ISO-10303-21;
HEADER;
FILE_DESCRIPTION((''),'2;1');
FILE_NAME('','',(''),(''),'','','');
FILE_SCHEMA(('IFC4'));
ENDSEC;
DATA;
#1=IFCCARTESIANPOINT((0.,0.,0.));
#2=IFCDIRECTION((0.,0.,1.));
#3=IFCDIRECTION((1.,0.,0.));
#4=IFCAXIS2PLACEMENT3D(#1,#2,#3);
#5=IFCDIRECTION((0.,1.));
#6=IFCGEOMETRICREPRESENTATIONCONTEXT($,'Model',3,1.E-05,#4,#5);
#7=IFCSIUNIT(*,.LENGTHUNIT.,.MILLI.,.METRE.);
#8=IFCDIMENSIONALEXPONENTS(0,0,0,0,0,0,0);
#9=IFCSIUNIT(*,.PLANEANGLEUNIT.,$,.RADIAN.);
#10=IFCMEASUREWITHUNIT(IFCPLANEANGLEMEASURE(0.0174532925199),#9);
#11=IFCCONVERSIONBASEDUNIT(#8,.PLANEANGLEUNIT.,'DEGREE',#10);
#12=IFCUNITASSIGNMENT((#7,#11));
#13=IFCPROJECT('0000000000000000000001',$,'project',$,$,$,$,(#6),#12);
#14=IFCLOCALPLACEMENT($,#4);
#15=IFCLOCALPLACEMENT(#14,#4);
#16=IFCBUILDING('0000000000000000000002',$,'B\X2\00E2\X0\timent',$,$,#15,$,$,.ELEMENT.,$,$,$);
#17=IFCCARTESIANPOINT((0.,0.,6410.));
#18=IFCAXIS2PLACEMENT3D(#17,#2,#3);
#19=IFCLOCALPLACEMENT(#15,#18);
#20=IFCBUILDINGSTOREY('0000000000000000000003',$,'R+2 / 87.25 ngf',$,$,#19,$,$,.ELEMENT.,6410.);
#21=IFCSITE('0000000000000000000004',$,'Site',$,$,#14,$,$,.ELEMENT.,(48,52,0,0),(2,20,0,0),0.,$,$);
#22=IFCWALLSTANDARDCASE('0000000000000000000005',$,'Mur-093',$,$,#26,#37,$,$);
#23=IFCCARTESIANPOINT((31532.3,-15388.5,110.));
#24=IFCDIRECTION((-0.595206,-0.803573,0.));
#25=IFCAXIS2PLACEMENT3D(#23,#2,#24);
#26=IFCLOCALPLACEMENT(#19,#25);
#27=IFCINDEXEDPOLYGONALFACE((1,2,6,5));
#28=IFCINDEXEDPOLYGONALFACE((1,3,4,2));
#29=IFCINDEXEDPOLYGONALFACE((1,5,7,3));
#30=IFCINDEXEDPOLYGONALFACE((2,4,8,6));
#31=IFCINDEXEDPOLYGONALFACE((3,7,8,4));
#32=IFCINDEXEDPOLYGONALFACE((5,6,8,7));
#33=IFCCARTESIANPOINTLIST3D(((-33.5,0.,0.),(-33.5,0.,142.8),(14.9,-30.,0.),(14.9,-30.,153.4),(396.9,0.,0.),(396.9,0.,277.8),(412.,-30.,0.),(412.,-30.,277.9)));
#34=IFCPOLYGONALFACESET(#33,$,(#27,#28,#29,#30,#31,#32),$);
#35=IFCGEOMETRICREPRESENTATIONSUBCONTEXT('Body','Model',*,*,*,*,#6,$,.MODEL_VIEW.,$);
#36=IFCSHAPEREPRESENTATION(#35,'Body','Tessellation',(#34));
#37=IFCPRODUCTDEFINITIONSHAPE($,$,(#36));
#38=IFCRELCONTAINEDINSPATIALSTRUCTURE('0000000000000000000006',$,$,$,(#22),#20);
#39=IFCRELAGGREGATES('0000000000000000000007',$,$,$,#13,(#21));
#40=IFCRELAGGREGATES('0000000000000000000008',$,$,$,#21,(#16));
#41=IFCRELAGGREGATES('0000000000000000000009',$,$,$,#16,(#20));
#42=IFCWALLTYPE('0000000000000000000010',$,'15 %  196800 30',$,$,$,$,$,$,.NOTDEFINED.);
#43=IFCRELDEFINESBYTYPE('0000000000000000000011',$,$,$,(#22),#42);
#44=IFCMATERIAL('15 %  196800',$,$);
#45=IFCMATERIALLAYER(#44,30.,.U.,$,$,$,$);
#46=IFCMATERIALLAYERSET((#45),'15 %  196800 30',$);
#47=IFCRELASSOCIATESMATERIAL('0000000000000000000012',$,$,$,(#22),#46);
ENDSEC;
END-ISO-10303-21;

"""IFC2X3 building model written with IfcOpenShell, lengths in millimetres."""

from ifc_helpers import new_model, entity, si_unit, converted_unit, direction, frame, origin_with_axes, place, context, subcontext, project, spatial, polyline, outline, extrude, clip, halfspace, material, layer, layer_set, layer_usage, type_object, element, save


model = new_model("IFC2X3")

# Units and contexts
model_context = context("Model", 3, precision=1e-05, world=origin_with_axes(), true_north=direction((0.0, 1.0)))
body_context = subcontext(model_context, "Body", "Model", "MODEL_VIEW")
ifc_project = project(units=[si_unit("LENGTHUNIT", "METRE", prefix="MILLI"), converted_unit("PLANEANGLEUNIT", "DEGREE", entity("IfcPlaneAngleMeasure", 0.0174532925199), si_unit("PLANEANGLEUNIT", "RADIAN"), dimensions=[0, 0, 0, 0, 0, 0, 0])], contexts=[model_context])

# Site, building, storey
site_placement = place(None, origin_with_axes())
site = spatial("IfcSite", under=ifc_project, at=site_placement, Name="Site", CompositionType="ELEMENT", RefLatitude=(48, 52, 0, 0), RefLongitude=(2, 20, 0, 0), RefElevation=0.0)
building_placement = place(site_placement, origin_with_axes())
building = spatial("IfcBuilding", under=site, at=building_placement, Name="Bâtiment", CompositionType="ELEMENT")
storey_placement = place(building_placement, frame((0.0, 0.0, 6410.0), z_axis=(0.0, 0.0, 1.0), x_axis=(1.0, 0.0, 0.0)))
storey = spatial("IfcBuildingStorey", under=building, at=storey_placement, Name="R+2 / 87.25 ngf", CompositionType="ELEMENT", Elevation=6410.0)

# Wall
ifc_material_1 = material(Name="15 %  196800")
ifc_layer = layer(ifc_material_1, 30.0, ventilated="UNKNOWN")
ifc_layer_set = layer_set([ifc_layer], Name="15 %  196800 30")
ifc_layer_usage = layer_usage(ifc_layer_set, "AXIS2", "POSITIVE", -30.0)
wall_type = type_object("IfcWallType", Name="15 %  196800 30", PredefinedType="NOTDEFINED")
wall_placement = place(storey_placement, frame((31532.3, -15388.5, 110.0), z_axis=(0.0, 0.0, 1.0), x_axis=(-0.595206, -0.803573, 0.0)))
element("IfcWallStandardCase", 1, at=wall_placement, inside=storey, type_object=wall_type, material=ifc_layer_usage, Name="Mur-093", context=body_context, shape_type="Clipping", body=[
    clip(extrude(outline(polyline([(14.9, -30.0), (412.0, -30.0), (396.9, 0.0), (-33.5, 0.0), (14.9, -30.0)])), origin_with_axes(), (0.0, 0.0, 1.0), 590.0), halfspace(frame((-42.8, -21.2, 136.6), z_axis=(0.296048, 0.146584, -0.943858), x_axis=(0.0, 0.988154, 0.153463)), True)),
])

save(model, "model.ifc")
